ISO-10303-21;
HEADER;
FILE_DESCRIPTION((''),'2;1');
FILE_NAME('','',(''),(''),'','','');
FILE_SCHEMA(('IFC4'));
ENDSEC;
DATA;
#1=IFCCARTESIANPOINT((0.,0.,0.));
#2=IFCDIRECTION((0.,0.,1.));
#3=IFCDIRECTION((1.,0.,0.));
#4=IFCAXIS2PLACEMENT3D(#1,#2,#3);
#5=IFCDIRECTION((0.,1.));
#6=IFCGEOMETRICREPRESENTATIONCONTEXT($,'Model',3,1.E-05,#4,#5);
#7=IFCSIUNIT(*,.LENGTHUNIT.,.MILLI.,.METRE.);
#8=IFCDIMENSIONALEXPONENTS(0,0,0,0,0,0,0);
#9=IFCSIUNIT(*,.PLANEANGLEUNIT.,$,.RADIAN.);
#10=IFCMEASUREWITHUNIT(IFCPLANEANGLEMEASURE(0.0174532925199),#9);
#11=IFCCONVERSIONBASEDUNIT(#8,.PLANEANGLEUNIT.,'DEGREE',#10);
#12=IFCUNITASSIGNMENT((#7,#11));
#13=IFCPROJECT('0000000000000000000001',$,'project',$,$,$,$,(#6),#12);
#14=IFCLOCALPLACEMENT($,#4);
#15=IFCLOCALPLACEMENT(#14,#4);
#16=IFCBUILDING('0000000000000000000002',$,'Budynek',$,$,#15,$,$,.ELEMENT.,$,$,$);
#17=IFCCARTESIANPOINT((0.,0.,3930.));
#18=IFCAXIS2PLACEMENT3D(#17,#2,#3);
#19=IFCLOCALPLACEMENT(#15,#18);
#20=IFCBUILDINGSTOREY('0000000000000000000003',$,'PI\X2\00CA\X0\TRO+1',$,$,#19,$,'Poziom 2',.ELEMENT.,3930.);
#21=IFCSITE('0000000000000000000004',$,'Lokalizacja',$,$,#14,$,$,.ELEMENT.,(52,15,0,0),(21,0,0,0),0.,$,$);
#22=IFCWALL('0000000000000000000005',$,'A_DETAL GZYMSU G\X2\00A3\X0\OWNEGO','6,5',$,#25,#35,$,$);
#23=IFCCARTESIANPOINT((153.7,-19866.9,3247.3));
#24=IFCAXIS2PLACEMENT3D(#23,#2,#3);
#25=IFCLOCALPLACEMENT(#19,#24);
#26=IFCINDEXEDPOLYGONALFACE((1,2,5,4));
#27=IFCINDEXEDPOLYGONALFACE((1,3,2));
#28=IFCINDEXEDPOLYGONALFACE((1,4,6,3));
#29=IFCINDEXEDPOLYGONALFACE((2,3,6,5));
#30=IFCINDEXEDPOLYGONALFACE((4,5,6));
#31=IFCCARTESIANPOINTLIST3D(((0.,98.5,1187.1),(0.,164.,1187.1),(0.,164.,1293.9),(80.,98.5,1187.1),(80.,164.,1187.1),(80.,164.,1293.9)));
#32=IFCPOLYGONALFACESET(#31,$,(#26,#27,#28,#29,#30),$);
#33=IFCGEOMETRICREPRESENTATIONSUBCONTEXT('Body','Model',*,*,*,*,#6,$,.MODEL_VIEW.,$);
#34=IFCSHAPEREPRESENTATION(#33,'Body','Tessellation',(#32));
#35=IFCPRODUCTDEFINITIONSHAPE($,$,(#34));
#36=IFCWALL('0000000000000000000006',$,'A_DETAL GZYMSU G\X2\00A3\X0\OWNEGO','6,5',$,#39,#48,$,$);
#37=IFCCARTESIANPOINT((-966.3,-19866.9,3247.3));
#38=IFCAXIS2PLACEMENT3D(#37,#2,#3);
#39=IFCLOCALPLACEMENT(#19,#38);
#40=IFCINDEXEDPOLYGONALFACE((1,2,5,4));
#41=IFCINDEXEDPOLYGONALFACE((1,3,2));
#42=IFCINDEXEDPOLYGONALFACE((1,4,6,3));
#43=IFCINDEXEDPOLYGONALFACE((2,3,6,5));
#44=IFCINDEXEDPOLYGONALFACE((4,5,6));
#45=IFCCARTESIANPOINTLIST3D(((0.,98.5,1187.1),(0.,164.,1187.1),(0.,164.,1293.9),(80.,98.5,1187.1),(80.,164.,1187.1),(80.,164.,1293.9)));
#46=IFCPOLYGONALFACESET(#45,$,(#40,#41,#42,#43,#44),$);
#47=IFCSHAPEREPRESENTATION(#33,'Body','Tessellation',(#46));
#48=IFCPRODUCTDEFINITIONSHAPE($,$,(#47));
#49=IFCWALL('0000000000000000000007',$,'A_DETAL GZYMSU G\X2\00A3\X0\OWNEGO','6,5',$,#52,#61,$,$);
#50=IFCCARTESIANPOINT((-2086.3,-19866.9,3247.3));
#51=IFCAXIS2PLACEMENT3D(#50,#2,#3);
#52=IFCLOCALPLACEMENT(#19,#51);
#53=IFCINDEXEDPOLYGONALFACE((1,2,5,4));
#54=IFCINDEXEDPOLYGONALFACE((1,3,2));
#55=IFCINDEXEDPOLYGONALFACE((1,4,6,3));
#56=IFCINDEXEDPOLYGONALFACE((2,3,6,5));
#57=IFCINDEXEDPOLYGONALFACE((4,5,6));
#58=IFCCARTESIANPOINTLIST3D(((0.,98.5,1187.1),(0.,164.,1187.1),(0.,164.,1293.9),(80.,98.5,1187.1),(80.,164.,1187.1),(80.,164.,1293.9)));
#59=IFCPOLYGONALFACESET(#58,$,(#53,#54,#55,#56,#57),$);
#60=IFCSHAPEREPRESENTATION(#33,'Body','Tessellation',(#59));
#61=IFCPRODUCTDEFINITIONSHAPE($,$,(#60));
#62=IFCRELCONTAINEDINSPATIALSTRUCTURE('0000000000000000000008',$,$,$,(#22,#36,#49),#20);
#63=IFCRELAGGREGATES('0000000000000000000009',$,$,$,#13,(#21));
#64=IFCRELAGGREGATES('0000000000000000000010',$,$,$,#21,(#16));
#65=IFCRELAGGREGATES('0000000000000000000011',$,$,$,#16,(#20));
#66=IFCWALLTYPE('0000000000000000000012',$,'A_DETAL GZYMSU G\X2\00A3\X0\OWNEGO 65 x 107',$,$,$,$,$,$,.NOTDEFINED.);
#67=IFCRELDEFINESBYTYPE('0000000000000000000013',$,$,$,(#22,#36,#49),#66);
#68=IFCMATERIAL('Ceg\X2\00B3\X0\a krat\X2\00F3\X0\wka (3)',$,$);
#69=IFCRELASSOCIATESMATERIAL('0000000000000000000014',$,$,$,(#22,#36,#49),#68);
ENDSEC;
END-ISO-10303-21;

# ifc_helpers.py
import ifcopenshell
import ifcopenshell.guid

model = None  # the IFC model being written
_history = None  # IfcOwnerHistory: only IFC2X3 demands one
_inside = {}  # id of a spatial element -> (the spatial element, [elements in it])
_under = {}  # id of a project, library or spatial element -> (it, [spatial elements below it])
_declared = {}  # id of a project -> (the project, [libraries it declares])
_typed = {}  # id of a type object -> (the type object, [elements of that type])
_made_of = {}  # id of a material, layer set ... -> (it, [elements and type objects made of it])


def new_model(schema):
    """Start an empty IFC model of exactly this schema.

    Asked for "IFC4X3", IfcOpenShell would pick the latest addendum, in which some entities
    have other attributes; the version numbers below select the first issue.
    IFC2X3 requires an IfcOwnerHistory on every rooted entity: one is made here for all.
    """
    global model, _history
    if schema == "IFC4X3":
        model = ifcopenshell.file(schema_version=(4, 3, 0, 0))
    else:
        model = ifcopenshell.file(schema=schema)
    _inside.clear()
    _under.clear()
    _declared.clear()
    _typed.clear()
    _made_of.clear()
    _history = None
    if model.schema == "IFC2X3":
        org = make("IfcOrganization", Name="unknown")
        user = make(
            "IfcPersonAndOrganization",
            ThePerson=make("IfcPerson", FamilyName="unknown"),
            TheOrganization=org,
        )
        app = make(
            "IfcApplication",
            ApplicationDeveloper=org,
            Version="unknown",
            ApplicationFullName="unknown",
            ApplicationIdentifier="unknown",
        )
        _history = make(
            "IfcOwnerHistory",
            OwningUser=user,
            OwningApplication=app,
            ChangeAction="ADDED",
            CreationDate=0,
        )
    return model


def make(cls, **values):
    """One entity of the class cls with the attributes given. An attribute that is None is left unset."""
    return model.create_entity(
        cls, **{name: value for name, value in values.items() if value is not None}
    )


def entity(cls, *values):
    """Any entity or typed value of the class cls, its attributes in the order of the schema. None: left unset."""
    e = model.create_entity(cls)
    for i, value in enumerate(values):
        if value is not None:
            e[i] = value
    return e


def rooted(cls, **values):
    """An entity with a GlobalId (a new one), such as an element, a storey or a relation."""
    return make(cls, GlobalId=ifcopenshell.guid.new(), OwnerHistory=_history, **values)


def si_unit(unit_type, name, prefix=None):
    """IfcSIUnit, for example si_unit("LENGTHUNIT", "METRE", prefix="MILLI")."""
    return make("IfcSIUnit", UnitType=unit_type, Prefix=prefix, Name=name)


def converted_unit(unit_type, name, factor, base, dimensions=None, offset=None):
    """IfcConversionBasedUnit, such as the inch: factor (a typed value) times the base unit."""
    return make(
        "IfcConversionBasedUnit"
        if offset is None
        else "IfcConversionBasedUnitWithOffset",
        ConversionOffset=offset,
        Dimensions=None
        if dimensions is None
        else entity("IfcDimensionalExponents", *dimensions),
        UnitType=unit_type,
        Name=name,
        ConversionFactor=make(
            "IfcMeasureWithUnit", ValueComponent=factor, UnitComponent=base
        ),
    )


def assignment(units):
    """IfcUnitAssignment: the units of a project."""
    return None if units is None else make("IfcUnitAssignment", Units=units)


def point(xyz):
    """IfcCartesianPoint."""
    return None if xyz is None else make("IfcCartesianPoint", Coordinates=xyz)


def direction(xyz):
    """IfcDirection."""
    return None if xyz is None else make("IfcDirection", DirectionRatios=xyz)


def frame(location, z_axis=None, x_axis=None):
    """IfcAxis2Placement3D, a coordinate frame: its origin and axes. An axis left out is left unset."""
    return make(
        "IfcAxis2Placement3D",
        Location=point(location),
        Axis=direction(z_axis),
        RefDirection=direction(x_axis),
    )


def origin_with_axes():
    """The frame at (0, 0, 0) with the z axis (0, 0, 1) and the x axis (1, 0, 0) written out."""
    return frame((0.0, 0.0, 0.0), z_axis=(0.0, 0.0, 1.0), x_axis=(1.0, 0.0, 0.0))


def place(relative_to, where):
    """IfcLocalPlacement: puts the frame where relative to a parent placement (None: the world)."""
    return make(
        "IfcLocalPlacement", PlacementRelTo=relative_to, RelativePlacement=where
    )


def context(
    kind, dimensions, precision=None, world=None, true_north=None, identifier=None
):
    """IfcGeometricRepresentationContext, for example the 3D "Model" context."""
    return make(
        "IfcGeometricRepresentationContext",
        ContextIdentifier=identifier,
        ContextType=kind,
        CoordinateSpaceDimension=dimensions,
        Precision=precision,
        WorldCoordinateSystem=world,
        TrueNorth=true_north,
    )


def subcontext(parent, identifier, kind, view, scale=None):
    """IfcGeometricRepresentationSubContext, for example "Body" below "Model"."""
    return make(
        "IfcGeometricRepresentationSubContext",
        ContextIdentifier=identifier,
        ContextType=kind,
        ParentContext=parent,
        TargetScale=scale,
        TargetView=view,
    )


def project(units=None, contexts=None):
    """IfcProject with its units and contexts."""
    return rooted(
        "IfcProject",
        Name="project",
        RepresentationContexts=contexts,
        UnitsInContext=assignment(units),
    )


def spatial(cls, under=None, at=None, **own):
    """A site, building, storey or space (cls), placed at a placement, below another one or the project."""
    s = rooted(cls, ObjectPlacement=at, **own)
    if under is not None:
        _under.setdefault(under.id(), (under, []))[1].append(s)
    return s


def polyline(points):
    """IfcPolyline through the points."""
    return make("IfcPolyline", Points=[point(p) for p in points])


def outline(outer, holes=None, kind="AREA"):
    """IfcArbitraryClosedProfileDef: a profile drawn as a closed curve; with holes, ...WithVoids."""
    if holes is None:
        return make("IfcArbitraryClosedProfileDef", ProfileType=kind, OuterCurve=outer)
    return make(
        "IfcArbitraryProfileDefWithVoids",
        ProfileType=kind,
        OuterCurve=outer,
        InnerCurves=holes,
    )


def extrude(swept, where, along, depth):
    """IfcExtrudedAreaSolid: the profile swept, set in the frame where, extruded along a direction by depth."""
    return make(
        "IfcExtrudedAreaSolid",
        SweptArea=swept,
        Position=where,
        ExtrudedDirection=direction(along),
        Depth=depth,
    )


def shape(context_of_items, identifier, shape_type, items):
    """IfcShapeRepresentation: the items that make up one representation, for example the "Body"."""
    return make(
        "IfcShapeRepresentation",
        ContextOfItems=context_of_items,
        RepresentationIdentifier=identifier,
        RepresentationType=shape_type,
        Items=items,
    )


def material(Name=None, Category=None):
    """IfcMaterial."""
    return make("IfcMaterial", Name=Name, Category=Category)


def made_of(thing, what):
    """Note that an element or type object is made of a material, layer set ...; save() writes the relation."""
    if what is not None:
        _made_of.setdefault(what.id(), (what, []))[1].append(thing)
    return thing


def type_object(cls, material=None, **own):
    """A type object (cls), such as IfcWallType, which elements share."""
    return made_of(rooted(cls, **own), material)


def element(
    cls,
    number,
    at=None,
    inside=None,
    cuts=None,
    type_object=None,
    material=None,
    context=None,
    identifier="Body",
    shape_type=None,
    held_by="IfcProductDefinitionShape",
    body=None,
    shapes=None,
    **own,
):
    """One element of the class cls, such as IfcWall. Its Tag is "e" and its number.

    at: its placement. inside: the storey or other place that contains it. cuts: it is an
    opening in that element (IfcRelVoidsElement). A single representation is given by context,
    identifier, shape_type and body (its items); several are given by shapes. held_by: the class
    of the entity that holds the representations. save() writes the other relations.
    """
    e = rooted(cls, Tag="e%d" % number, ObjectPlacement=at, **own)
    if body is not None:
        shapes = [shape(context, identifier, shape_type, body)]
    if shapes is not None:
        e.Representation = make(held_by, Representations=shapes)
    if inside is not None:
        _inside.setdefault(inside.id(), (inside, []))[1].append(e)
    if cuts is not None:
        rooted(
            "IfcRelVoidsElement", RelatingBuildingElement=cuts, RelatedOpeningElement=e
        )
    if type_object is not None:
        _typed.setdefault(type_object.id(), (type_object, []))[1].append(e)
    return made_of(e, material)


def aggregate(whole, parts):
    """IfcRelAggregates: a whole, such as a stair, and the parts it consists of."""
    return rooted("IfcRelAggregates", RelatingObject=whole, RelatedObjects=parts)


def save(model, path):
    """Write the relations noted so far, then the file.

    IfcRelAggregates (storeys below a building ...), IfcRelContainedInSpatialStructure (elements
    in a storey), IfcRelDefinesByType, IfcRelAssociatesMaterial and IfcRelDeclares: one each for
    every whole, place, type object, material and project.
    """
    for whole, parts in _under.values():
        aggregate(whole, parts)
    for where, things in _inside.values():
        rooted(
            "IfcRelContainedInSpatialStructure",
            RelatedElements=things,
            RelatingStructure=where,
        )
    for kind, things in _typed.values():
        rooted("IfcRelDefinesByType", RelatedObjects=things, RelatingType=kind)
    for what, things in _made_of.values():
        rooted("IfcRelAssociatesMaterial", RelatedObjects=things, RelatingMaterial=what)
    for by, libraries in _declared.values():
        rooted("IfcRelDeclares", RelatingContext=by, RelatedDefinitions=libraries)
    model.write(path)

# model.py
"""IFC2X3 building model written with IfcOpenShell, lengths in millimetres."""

from ifc_helpers import new_model, entity, si_unit, converted_unit, direction, frame, origin_with_axes, place, context, subcontext, project, spatial, polyline, outline, extrude, material, type_object, element, save


model = new_model("IFC2X3")

# Units and contexts
model_context = context("Model", 3, precision=1e-05, world=origin_with_axes(), true_north=direction((0.0, 1.0)))
body_context = subcontext(model_context, "Body", "Model", "MODEL_VIEW")
ifc_project = project(units=[si_unit("LENGTHUNIT", "METRE", prefix="MILLI"), converted_unit("PLANEANGLEUNIT", "DEGREE", entity("IfcPlaneAngleMeasure", 0.0174532925199), si_unit("PLANEANGLEUNIT", "RADIAN"), dimensions=[0, 0, 0, 0, 0, 0, 0])], contexts=[model_context])

# Site, building, storey
site_placement = place(None, origin_with_axes())
site = spatial("IfcSite", under=ifc_project, at=site_placement, Name="Lokalizacja", CompositionType="ELEMENT", RefLatitude=(52, 15, 0, 0), RefLongitude=(21, 0, 0, 0), RefElevation=0.0)
building_placement = place(site_placement, origin_with_axes())
building = spatial("IfcBuilding", under=site, at=building_placement, Name="Budynek", CompositionType="ELEMENT")
storey_placement = place(building_placement, frame((0.0, 0.0, 3930.0), z_axis=(0.0, 0.0, 1.0), x_axis=(1.0, 0.0, 0.0)))
storey = spatial("IfcBuildingStorey", under=building, at=storey_placement, Name="PIÊTRO+1", LongName="Poziom 2", CompositionType="ELEMENT", Elevation=3930.0)

# Walls
ifc_material = material(Name="Ceg³a kratówka (3)")
wall_type = type_object("IfcWallType", Name="A_DETAL GZYMSU G£OWNEGO 65 x 107", PredefinedType="NOTDEFINED")
for number, where, z_axis, x_axis, name in (
    (1, (153.7, -19866.9, 3247.3), (0.0, 0.0, 1.0), (1.0, 0.0, 0.0), "A_DETAL GZYMSU G£OWNEGO"),
    (2, (-966.3, -19866.9, 3247.3), (0.0, 0.0, 1.0), (1.0, 0.0, 0.0), "A_DETAL GZYMSU G£OWNEGO"),
    (3, (-2086.3, -19866.9, 3247.3), (0.0, 0.0, 1.0), (1.0, 0.0, 0.0), "A_DETAL GZYMSU G£OWNEGO"),
):
    element("IfcWall", number, at=place(storey_placement, frame(where, z_axis=z_axis, x_axis=x_axis)), inside=storey, type_object=wall_type, material=ifc_material, Name=name, Description="6,5", context=body_context, shape_type="SweptSolid", body=[
        extrude(outline(polyline([(-164.0, 1293.9), (-164.0, 1187.1), (-98.5, 1187.1), (-164.0, 1293.9)])), frame((0.0, 0.0, 0.0), z_axis=(-1.0, 0.0, 0.0), x_axis=(0.0, -1.0, 0.0)), (0.0, 0.0, -1.0), 80.0),
    ])

save(model, "model.ifc")
